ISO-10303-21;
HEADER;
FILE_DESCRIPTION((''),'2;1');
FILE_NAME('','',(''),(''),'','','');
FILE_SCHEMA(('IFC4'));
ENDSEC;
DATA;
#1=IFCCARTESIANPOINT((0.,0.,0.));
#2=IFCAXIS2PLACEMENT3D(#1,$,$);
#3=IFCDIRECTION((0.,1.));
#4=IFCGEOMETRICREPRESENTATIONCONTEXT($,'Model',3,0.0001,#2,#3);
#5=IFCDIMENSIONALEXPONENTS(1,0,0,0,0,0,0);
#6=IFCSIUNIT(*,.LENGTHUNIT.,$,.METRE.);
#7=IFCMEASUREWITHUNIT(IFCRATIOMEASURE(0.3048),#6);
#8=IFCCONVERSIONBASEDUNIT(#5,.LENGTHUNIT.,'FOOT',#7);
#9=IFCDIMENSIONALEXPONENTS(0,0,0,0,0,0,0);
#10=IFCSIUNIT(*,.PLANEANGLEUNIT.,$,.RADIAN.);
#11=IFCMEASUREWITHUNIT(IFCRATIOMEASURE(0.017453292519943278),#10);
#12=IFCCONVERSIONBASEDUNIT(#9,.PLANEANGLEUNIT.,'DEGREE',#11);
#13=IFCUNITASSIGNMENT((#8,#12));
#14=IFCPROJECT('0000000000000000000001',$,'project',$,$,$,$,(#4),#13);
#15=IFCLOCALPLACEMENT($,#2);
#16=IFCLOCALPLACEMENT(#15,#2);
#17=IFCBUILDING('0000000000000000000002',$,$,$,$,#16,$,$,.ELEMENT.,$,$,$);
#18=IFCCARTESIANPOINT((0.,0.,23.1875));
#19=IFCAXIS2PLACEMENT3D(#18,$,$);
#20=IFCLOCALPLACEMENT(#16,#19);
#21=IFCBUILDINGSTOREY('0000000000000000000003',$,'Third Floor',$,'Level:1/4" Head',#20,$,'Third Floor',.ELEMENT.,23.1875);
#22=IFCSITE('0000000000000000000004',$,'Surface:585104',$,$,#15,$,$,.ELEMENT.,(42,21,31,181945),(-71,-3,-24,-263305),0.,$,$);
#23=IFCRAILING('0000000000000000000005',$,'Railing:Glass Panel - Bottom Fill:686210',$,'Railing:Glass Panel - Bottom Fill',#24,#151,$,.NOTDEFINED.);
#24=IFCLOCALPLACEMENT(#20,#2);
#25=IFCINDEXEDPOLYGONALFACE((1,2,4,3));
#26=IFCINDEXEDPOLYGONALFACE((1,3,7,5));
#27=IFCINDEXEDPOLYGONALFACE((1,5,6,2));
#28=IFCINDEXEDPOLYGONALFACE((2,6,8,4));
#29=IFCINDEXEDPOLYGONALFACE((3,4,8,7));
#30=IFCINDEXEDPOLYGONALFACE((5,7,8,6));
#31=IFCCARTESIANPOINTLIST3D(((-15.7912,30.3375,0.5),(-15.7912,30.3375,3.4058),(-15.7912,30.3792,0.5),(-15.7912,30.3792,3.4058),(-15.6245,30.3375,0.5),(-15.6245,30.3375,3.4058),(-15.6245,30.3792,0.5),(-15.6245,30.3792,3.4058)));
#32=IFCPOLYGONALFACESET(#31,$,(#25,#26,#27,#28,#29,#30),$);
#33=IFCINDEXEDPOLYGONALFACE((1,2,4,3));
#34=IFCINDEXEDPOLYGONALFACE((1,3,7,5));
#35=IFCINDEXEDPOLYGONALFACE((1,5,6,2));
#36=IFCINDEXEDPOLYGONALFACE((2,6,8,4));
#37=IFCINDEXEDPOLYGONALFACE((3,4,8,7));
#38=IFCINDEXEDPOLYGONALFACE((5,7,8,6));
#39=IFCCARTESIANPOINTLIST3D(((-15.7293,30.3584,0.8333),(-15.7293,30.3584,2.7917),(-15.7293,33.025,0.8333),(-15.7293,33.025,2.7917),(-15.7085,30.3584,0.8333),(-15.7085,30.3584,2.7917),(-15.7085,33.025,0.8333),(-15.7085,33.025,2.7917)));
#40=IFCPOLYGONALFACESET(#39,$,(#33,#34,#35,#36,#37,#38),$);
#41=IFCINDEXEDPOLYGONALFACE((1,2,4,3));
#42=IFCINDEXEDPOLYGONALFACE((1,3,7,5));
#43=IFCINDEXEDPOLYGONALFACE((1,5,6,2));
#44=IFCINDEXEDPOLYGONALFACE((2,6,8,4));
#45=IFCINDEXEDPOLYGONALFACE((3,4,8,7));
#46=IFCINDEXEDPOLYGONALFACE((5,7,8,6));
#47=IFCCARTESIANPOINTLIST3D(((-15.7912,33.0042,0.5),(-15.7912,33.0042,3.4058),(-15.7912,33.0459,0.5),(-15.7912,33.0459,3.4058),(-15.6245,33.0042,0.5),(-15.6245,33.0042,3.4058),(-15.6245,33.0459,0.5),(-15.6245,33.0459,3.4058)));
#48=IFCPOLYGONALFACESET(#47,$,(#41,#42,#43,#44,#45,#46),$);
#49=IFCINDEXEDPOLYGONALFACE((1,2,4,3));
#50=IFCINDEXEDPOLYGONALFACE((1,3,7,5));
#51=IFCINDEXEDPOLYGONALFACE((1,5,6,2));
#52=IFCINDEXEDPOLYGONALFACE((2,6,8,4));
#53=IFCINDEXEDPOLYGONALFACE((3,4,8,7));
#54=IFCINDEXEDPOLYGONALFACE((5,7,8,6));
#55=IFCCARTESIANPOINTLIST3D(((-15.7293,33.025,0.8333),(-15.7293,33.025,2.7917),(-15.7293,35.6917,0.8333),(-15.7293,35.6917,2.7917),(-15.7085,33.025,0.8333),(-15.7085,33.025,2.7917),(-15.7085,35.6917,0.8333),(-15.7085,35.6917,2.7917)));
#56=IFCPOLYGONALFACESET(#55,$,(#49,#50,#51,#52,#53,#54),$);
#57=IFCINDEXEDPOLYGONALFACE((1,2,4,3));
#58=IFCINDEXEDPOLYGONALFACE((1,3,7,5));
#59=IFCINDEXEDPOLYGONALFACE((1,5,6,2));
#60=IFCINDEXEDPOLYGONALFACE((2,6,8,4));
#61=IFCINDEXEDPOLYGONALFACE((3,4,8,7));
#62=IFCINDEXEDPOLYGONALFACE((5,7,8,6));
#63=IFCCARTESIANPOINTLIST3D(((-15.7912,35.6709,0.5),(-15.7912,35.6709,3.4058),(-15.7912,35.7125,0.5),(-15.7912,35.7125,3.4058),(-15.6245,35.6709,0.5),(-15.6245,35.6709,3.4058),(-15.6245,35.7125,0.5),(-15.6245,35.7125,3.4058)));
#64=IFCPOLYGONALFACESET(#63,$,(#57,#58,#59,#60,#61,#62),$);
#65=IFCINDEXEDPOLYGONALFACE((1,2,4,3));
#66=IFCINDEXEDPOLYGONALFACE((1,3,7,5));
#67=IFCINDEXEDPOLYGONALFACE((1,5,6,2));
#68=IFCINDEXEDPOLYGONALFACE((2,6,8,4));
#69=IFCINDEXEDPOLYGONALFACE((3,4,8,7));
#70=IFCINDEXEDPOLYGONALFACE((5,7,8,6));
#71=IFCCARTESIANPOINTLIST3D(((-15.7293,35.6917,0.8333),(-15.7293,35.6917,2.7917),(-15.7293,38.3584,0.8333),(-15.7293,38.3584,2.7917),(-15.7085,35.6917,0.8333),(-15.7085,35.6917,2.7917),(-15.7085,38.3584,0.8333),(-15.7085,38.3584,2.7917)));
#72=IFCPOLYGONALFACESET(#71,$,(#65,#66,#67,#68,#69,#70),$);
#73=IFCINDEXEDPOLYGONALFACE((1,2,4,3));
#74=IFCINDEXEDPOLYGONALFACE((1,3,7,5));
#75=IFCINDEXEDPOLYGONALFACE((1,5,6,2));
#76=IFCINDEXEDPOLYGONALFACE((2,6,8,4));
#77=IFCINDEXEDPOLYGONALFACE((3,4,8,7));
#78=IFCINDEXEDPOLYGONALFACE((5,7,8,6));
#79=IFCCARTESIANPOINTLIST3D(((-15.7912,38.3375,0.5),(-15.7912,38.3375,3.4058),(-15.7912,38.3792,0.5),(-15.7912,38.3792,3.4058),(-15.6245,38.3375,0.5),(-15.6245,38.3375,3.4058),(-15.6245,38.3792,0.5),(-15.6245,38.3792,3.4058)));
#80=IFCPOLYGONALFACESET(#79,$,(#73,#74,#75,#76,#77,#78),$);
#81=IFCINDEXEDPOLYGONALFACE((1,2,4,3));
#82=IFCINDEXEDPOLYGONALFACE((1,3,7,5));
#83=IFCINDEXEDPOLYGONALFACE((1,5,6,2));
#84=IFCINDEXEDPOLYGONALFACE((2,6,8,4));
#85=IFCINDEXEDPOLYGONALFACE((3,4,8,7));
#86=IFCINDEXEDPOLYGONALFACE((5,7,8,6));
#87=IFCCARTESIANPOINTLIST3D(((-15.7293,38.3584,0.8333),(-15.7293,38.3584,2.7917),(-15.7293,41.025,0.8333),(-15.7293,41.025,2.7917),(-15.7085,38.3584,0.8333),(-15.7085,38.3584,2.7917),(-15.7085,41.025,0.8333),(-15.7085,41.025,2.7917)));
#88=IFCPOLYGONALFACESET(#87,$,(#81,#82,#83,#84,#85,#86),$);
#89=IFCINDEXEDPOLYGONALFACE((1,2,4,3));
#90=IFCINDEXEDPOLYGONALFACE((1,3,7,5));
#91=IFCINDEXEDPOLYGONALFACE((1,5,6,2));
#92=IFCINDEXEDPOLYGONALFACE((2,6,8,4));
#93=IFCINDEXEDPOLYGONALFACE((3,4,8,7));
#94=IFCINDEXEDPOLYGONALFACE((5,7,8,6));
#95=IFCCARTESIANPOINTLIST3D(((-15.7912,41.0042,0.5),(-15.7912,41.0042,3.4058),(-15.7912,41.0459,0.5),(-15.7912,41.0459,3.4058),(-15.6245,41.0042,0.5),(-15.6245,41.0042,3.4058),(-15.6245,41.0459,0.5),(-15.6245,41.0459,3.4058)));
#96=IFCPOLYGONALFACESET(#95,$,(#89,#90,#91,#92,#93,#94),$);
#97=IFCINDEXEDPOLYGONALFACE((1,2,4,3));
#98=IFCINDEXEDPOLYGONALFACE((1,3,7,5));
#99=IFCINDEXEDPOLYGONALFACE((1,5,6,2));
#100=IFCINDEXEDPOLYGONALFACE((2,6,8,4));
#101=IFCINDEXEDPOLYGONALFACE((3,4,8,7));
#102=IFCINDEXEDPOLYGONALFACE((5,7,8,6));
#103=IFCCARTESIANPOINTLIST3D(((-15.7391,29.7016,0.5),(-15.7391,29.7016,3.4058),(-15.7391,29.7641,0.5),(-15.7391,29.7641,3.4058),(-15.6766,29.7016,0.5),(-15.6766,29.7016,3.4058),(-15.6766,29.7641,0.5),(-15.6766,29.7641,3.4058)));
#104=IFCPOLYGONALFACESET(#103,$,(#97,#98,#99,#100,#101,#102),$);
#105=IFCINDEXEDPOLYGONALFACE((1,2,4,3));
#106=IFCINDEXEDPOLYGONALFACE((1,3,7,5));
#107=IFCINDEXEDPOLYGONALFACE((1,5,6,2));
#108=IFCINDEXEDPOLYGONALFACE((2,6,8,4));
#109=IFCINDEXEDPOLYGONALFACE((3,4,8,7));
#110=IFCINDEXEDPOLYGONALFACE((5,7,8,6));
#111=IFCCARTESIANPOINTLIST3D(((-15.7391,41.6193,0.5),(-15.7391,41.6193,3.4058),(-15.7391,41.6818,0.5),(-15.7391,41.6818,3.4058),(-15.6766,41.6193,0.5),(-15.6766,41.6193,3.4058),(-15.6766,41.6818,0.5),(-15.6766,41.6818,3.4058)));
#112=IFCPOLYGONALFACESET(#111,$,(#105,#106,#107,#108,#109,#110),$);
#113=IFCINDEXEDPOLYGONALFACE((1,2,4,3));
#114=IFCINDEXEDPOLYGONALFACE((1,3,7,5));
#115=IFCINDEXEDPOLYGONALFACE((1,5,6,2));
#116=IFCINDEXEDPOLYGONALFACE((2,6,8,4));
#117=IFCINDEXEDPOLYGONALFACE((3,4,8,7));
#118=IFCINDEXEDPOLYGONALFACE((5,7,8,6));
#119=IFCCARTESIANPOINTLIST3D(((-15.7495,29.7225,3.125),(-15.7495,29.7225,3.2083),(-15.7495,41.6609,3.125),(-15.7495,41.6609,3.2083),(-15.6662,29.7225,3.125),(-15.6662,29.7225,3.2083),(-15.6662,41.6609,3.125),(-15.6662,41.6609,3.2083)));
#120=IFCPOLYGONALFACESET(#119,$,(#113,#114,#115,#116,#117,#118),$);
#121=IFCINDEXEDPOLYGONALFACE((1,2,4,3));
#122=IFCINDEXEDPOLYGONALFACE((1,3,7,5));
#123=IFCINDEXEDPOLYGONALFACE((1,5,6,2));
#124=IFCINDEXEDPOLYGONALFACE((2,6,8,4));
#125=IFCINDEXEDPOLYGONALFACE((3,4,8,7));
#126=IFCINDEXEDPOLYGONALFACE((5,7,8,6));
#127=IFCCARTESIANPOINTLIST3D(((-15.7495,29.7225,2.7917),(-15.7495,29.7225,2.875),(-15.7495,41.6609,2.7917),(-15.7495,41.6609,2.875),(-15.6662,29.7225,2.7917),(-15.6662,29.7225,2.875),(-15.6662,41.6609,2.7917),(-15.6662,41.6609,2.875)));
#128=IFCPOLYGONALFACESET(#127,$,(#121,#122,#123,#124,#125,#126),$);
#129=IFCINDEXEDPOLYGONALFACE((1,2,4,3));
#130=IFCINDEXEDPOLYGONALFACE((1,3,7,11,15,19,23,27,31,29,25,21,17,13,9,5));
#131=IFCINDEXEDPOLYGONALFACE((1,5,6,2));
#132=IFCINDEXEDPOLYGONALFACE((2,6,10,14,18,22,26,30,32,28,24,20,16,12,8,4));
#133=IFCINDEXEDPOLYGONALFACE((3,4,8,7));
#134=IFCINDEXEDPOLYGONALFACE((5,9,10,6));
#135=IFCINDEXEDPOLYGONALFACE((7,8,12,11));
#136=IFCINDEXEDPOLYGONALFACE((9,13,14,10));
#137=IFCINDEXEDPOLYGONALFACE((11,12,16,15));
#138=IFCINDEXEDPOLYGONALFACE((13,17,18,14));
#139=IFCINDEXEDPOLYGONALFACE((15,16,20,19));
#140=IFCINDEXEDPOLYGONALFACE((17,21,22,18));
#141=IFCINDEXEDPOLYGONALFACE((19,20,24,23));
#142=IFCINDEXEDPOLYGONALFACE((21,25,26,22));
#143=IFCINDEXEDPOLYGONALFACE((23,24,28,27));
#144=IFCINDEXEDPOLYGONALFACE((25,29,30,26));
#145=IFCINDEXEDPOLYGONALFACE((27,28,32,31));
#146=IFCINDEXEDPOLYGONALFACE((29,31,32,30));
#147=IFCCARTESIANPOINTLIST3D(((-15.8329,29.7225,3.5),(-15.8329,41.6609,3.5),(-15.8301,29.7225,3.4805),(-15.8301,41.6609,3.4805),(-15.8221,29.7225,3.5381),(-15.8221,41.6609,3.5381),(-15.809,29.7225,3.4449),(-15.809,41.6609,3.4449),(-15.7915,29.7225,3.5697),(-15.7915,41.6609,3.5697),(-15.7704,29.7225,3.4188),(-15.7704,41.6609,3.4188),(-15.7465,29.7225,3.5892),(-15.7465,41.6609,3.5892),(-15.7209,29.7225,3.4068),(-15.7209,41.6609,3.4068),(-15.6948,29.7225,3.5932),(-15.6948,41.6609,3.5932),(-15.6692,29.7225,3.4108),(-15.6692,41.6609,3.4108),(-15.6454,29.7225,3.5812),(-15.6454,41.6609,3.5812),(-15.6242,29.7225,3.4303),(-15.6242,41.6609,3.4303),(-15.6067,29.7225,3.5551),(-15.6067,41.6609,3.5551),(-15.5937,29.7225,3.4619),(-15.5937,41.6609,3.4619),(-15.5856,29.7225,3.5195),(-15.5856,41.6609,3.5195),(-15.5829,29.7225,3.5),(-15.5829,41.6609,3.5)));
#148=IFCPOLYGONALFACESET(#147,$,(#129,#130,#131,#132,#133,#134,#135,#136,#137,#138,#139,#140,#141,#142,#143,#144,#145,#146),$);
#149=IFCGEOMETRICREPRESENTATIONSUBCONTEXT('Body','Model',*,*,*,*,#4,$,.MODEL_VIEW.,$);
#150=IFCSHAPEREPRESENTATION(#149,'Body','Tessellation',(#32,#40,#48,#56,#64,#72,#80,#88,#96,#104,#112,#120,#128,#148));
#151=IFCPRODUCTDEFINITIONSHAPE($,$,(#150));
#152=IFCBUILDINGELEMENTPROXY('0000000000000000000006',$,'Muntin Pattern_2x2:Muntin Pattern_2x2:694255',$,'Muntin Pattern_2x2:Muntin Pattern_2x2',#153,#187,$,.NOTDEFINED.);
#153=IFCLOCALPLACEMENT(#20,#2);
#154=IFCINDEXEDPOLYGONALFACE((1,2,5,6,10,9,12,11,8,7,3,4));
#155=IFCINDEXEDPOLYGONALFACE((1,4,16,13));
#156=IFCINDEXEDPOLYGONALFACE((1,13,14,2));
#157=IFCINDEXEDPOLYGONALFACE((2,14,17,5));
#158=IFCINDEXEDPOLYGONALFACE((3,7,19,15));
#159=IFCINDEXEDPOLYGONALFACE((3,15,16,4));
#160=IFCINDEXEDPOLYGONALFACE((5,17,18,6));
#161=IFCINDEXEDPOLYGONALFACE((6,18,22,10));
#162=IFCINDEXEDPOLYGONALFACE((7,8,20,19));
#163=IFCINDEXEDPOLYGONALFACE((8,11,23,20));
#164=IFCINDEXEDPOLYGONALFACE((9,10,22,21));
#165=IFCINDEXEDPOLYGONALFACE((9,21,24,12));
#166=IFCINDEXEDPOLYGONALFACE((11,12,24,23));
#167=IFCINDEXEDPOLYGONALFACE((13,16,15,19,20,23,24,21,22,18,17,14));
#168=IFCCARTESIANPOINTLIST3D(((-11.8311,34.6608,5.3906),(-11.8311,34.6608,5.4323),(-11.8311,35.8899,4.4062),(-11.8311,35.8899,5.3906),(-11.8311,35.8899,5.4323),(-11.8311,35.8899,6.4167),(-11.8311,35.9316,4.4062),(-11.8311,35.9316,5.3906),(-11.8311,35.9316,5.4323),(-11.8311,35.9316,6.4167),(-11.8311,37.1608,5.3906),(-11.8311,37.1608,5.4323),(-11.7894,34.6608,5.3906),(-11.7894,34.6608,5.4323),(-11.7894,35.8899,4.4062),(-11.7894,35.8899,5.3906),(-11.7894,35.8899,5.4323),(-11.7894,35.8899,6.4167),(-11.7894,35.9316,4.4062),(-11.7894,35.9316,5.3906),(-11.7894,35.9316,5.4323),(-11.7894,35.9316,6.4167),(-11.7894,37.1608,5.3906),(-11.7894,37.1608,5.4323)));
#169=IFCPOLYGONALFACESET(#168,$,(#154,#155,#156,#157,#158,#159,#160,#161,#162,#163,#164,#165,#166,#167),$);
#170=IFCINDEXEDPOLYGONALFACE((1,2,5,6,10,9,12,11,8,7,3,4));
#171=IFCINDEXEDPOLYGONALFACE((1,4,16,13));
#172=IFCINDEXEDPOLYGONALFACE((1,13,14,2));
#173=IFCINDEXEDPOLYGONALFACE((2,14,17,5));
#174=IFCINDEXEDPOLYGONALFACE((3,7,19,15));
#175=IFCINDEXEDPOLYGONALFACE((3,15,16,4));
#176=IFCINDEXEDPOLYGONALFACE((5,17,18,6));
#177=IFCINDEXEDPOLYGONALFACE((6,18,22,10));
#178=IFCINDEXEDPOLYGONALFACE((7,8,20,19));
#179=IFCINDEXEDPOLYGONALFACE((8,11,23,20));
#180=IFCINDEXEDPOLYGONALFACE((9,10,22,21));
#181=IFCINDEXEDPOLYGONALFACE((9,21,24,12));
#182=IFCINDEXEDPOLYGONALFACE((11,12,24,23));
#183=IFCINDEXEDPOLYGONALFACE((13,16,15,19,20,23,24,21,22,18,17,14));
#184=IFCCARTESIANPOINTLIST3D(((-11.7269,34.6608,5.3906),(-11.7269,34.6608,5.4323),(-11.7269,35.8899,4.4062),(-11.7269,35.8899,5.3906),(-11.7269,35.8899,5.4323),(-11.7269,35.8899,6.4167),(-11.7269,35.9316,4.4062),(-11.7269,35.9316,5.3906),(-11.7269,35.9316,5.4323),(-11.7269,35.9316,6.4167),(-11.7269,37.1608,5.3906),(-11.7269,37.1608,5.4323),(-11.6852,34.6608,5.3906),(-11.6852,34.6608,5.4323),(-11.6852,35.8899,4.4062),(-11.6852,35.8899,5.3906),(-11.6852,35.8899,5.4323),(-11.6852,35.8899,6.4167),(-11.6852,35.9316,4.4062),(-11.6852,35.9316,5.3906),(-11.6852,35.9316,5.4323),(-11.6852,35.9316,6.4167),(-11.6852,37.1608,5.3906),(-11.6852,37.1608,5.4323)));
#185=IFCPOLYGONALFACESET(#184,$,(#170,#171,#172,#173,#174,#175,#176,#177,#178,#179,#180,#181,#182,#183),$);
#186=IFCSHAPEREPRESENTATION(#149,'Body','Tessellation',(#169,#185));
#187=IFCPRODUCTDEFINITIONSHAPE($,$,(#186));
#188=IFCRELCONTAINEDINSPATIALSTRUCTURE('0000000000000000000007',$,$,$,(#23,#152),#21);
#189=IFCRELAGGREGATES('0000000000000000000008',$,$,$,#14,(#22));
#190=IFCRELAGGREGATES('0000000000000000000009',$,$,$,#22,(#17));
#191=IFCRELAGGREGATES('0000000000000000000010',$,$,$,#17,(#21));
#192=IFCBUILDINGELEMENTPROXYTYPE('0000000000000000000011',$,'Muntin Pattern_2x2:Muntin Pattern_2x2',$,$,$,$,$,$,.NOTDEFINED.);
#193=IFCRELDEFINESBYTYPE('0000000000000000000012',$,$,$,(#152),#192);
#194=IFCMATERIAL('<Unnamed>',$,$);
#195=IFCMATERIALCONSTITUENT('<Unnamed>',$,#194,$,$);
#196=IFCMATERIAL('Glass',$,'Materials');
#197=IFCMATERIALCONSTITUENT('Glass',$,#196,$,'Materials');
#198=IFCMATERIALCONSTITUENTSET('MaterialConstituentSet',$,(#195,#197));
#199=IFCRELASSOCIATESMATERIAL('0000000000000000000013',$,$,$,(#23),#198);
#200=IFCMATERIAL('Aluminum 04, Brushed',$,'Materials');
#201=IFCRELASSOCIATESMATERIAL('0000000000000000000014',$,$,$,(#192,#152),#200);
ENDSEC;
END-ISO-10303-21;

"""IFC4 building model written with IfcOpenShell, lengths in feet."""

from ifc_helpers import new_model, entity, si_unit, converted_unit, direction, frame, origin, place, context, subcontext, project, spatial, indexed_curve, outline, extrude, source, transform, mapped, material, constituent, constituent_set, type_object, type_shapes, element, save


model = new_model("IFC4")

# Units and contexts
model_context = context("Model", 3, precision=0.0001, world=origin(), true_north=direction((0.0, 1.0)))
body_context = subcontext(model_context, "Body", "Model", "MODEL_VIEW")
ifc_project = project(units=[converted_unit("LENGTHUNIT", "FOOT", entity("IfcRatioMeasure", 0.3048), si_unit("LENGTHUNIT", "METRE"), dimensions=[1, 0, 0, 0, 0, 0, 0]), converted_unit("PLANEANGLEUNIT", "DEGREE", entity("IfcRatioMeasure", 0.017453292519943278), si_unit("PLANEANGLEUNIT", "RADIAN"), dimensions=[0, 0, 0, 0, 0, 0, 0])], contexts=[model_context])

# Site, building, storey
site_placement = place(None, origin())
site = spatial("IfcSite", under=ifc_project, at=site_placement, Name="Surface:585104", CompositionType="ELEMENT", RefLatitude=(42, 21, 31, 181945), RefLongitude=(-71, -3, -24, -263305), RefElevation=0.0)
building_placement = place(site_placement, origin())
building = spatial("IfcBuilding", under=site, at=building_placement, CompositionType="ELEMENT")
storey_placement = place(building_placement, frame((0.0, 0.0, 23.1875)))
storey = spatial("IfcBuildingStorey", under=building, at=storey_placement, Name="Third Floor", ObjectType="Level:1/4\" Head", LongName="Third Floor", CompositionType="ELEMENT", Elevation=23.1875)

# Shared definitions
ifc_material_1 = material(Name="Aluminum 04, Brushed", Category="Materials")

# Railing
ifc_material_2 = material(Name="<Unnamed>")
ifc_constituent_1 = constituent(ifc_material_2, Name="<Unnamed>")
ifc_material_3 = material(Name="Glass", Category="Materials")
ifc_constituent_2 = constituent(ifc_material_3, Name="Glass", Category="Materials")
ifc_constituent_set = constituent_set(constituents=[ifc_constituent_1, ifc_constituent_2], Name="MaterialConstituentSet")
railing_1_placement = place(storey_placement, origin())
element("IfcRailing", 1, at=railing_1_placement, inside=storey, material=ifc_constituent_set, Name="Railing:Glass Panel - Bottom Fill:686210", ObjectType="Railing:Glass Panel - Bottom Fill", PredefinedType="NOTDEFINED", context=body_context, shape_type="SweptSolid", body=[
    extrude(outline(indexed_curve([(-0.0833, -0.0208), (0.0833, -0.0208), (0.0833, 0.0208), (-0.0833, 0.0208), (-0.0833, -0.0208)], self_intersect=False)), frame((-15.7079, 30.3584, 0.5), z_axis=(0.0, 0.0, 1.0), x_axis=(-1.0, 0.0, 0.0)), (0.0, 0.0, 1.0), 2.9058),
    extrude(outline(indexed_curve([(-1.3333, -0.0104), (1.3333, -0.0104), (1.3333, 0.0104), (-1.3333, 0.0104), (-1.3333, -0.0104)], self_intersect=False)), frame((-15.7189, 31.6917, 0.8333), z_axis=(0.0, 0.0, 1.0), x_axis=(0.0, -1.0, 0.0)), (0.0, 0.0, 1.0), 1.9583),
    extrude(outline(indexed_curve([(-0.0833, -0.0208), (0.0833, -0.0208), (0.0833, 0.0208), (-0.0833, 0.0208), (-0.0833, -0.0208)], self_intersect=False)), frame((-15.7079, 33.025, 0.5), z_axis=(0.0, 0.0, 1.0), x_axis=(-1.0, 0.0, 0.0)), (0.0, 0.0, 1.0), 2.9058),
    extrude(outline(indexed_curve([(-1.3333, -0.0104), (1.3333, -0.0104), (1.3333, 0.0104), (-1.3333, 0.0104), (-1.3333, -0.0104)], self_intersect=False)), frame((-15.7189, 34.3584, 0.8333), z_axis=(0.0, 0.0, 1.0), x_axis=(0.0, -1.0, 0.0)), (0.0, 0.0, 1.0), 1.9583),
    extrude(outline(indexed_curve([(-0.0833, -0.0208), (0.0833, -0.0208), (0.0833, 0.0208), (-0.0833, 0.0208), (-0.0833, -0.0208)], self_intersect=False)), frame((-15.7079, 35.6917, 0.5), z_axis=(0.0, 0.0, 1.0), x_axis=(-1.0, 0.0, 0.0)), (0.0, 0.0, 1.0), 2.9058),
    extrude(outline(indexed_curve([(-1.3333, -0.0104), (1.3333, -0.0104), (1.3333, 0.0104), (-1.3333, 0.0104), (-1.3333, -0.0104)], self_intersect=False)), frame((-15.7189, 37.025, 0.8333), z_axis=(0.0, 0.0, 1.0), x_axis=(0.0, -1.0, 0.0)), (0.0, 0.0, 1.0), 1.9583),
    extrude(outline(indexed_curve([(-0.0833, -0.0208), (0.0833, -0.0208), (0.0833, 0.0208), (-0.0833, 0.0208), (-0.0833, -0.0208)], self_intersect=False)), frame((-15.7079, 38.3584, 0.5), z_axis=(0.0, 0.0, 1.0), x_axis=(-1.0, 0.0, 0.0)), (0.0, 0.0, 1.0), 2.9058),
    extrude(outline(indexed_curve([(-1.3333, -0.0104), (1.3333, -0.0104), (1.3333, 0.0104), (-1.3333, 0.0104), (-1.3333, -0.0104)], self_intersect=False)), frame((-15.7189, 39.6917, 0.8333), z_axis=(0.0, 0.0, 1.0), x_axis=(0.0, -1.0, 0.0)), (0.0, 0.0, 1.0), 1.9583),
    extrude(outline(indexed_curve([(-0.0833, -0.0208), (0.0833, -0.0208), (0.0833, 0.0208), (-0.0833, 0.0208), (-0.0833, -0.0208)], self_intersect=False)), frame((-15.7079, 41.025, 0.5), z_axis=(0.0, 0.0, 1.0), x_axis=(-1.0, 0.0, 0.0)), (0.0, 0.0, 1.0), 2.9058),
    extrude(outline(indexed_curve([(-0.0312, -0.0312), (0.0312, -0.0312), (0.0312, 0.0312), (-0.0312, 0.0312), (-0.0312, -0.0312)], self_intersect=False)), frame((-15.7079, 29.7329, 0.5), z_axis=(0.0, 0.0, 1.0), x_axis=(-1.0, 0.0, 0.0)), (0.0, 0.0, 1.0), 2.9058),
    extrude(outline(indexed_curve([(-0.0312, -0.0312), (0.0312, -0.0312), (0.0312, 0.0312), (-0.0312, 0.0312), (-0.0312, -0.0312)], self_intersect=False)), frame((-15.7079, 41.6505, 0.5), z_axis=(0.0, 0.0, 1.0), x_axis=(-1.0, 0.0, 0.0)), (0.0, 0.0, 1.0), 2.9058),
    extrude(outline(indexed_curve([(-5.9692, -0.0417), (5.9692, -0.0417), (5.9692, 0.0417), (-5.9692, 0.0417), (-5.9692, -0.0417)], self_intersect=False)), frame((-15.7079, 35.6917, 3.125), z_axis=(0.0, 0.0, 1.0), x_axis=(0.0, -1.0, 0.0)), (0.0, 0.0, 1.0), 0.0833),
    extrude(outline(indexed_curve([(-5.9692, -0.0417), (5.9692, -0.0417), (5.9692, 0.0417), (-5.9692, 0.0417), (-5.9692, -0.0417)], self_intersect=False)), frame((-15.7079, 35.6917, 2.7917), z_axis=(0.0, 0.0, 1.0), x_axis=(0.0, -1.0, 0.0)), (0.0, 0.0, 1.0), 0.0833),
    extrude(outline(indexed_curve([(-0.0341, -0.1203), (0.0055, -0.1203), (0.0442, -0.0995), (0.0753, -0.0615), (0.0933, -0.0129), (0.0952, 0.038), (0.0806, 0.0823), (0.0521, 0.1123), (0.0341, 0.1203), (-0.0055, 0.1203), (-0.0442, 0.0995), (-0.0753, 0.0615), (-0.0933, 0.0129), (-0.0952, -0.038), (-0.0806, -0.0823), (-0.0521, -0.1123), (-0.0341, -0.1203)], self_intersect=False)), frame((-15.7079, 29.7225, 3.5), z_axis=(0.0, 1.0, 0.0), x_axis=(-0.27267, 0.0, -0.962108)), (0.0, 0.0, 1.0), 11.9385),
])

# Building element proxy
building_element_proxy_type_1 = type_object("IfcBuildingElementProxyType", Name="Muntin Pattern_2x2:Muntin Pattern_2x2", PredefinedType="NOTDEFINED", material=ifc_material_1)
shared_shape_1 = source(origin(), body_context, "Body", "SweptSolid", [
    extrude(outline(indexed_curve([(0.0208, -0.0208), (1.0052, -0.0208), (1.0052, 0.0208), (0.0208, 0.0208), (0.0208, 1.25), (-0.0208, 1.25), (-0.0208, 0.0208), (-1.0052, 0.0208), (-1.0052, -0.0208), (-0.0208, -0.0208), (-0.0208, -1.25), (0.0208, -1.25), (0.0208, -0.0208)], self_intersect=False)), frame((0.0, -0.0729, 1.0052), z_axis=(0.0, 1.0, 0.0), x_axis=(0.0, 0.0, 1.0)), (0.0, 0.0, 1.0), 0.0417),
    extrude(outline(indexed_curve([(0.0208, -0.0208), (1.0052, -0.0208), (1.0052, 0.0208), (0.0208, 0.0208), (0.0208, 1.25), (-0.0208, 1.25), (-0.0208, 0.0208), (-1.0052, 0.0208), (-1.0052, -0.0208), (-0.0208, -0.0208), (-0.0208, -1.25), (0.0208, -1.25), (0.0208, -0.0208)], self_intersect=False)), frame((0.0, 0.0313, 1.0052), z_axis=(0.0, 1.0, 0.0), x_axis=(0.0, 0.0, 1.0)), (0.0, 0.0, 1.0), 0.0417),
])
type_shapes(building_element_proxy_type_1, [shared_shape_1])
for number, where, z_axis, x_axis, name in (
    (2, (-11.7582, 35.9108, 4.4062), (0.0, 0.0, 1.0), (0.0, -1.0, 0.0), "Muntin Pattern_2x2:Muntin Pattern_2x2:694255"),
):
    element("IfcBuildingElementProxy", number, at=place(storey_placement, frame(where, z_axis=z_axis, x_axis=x_axis)), inside=storey, type_object=building_element_proxy_type_1, material=ifc_material_1, Name=name, ObjectType="Muntin Pattern_2x2:Muntin Pattern_2x2", PredefinedType="NOTDEFINED", context=body_context, shape_type="MappedRepresentation", body=[
        mapped(shared_shape_1, transform((0.0, 0.0, 0.0), scale=1.0)),
    ])

save(model, "model.ifc")
